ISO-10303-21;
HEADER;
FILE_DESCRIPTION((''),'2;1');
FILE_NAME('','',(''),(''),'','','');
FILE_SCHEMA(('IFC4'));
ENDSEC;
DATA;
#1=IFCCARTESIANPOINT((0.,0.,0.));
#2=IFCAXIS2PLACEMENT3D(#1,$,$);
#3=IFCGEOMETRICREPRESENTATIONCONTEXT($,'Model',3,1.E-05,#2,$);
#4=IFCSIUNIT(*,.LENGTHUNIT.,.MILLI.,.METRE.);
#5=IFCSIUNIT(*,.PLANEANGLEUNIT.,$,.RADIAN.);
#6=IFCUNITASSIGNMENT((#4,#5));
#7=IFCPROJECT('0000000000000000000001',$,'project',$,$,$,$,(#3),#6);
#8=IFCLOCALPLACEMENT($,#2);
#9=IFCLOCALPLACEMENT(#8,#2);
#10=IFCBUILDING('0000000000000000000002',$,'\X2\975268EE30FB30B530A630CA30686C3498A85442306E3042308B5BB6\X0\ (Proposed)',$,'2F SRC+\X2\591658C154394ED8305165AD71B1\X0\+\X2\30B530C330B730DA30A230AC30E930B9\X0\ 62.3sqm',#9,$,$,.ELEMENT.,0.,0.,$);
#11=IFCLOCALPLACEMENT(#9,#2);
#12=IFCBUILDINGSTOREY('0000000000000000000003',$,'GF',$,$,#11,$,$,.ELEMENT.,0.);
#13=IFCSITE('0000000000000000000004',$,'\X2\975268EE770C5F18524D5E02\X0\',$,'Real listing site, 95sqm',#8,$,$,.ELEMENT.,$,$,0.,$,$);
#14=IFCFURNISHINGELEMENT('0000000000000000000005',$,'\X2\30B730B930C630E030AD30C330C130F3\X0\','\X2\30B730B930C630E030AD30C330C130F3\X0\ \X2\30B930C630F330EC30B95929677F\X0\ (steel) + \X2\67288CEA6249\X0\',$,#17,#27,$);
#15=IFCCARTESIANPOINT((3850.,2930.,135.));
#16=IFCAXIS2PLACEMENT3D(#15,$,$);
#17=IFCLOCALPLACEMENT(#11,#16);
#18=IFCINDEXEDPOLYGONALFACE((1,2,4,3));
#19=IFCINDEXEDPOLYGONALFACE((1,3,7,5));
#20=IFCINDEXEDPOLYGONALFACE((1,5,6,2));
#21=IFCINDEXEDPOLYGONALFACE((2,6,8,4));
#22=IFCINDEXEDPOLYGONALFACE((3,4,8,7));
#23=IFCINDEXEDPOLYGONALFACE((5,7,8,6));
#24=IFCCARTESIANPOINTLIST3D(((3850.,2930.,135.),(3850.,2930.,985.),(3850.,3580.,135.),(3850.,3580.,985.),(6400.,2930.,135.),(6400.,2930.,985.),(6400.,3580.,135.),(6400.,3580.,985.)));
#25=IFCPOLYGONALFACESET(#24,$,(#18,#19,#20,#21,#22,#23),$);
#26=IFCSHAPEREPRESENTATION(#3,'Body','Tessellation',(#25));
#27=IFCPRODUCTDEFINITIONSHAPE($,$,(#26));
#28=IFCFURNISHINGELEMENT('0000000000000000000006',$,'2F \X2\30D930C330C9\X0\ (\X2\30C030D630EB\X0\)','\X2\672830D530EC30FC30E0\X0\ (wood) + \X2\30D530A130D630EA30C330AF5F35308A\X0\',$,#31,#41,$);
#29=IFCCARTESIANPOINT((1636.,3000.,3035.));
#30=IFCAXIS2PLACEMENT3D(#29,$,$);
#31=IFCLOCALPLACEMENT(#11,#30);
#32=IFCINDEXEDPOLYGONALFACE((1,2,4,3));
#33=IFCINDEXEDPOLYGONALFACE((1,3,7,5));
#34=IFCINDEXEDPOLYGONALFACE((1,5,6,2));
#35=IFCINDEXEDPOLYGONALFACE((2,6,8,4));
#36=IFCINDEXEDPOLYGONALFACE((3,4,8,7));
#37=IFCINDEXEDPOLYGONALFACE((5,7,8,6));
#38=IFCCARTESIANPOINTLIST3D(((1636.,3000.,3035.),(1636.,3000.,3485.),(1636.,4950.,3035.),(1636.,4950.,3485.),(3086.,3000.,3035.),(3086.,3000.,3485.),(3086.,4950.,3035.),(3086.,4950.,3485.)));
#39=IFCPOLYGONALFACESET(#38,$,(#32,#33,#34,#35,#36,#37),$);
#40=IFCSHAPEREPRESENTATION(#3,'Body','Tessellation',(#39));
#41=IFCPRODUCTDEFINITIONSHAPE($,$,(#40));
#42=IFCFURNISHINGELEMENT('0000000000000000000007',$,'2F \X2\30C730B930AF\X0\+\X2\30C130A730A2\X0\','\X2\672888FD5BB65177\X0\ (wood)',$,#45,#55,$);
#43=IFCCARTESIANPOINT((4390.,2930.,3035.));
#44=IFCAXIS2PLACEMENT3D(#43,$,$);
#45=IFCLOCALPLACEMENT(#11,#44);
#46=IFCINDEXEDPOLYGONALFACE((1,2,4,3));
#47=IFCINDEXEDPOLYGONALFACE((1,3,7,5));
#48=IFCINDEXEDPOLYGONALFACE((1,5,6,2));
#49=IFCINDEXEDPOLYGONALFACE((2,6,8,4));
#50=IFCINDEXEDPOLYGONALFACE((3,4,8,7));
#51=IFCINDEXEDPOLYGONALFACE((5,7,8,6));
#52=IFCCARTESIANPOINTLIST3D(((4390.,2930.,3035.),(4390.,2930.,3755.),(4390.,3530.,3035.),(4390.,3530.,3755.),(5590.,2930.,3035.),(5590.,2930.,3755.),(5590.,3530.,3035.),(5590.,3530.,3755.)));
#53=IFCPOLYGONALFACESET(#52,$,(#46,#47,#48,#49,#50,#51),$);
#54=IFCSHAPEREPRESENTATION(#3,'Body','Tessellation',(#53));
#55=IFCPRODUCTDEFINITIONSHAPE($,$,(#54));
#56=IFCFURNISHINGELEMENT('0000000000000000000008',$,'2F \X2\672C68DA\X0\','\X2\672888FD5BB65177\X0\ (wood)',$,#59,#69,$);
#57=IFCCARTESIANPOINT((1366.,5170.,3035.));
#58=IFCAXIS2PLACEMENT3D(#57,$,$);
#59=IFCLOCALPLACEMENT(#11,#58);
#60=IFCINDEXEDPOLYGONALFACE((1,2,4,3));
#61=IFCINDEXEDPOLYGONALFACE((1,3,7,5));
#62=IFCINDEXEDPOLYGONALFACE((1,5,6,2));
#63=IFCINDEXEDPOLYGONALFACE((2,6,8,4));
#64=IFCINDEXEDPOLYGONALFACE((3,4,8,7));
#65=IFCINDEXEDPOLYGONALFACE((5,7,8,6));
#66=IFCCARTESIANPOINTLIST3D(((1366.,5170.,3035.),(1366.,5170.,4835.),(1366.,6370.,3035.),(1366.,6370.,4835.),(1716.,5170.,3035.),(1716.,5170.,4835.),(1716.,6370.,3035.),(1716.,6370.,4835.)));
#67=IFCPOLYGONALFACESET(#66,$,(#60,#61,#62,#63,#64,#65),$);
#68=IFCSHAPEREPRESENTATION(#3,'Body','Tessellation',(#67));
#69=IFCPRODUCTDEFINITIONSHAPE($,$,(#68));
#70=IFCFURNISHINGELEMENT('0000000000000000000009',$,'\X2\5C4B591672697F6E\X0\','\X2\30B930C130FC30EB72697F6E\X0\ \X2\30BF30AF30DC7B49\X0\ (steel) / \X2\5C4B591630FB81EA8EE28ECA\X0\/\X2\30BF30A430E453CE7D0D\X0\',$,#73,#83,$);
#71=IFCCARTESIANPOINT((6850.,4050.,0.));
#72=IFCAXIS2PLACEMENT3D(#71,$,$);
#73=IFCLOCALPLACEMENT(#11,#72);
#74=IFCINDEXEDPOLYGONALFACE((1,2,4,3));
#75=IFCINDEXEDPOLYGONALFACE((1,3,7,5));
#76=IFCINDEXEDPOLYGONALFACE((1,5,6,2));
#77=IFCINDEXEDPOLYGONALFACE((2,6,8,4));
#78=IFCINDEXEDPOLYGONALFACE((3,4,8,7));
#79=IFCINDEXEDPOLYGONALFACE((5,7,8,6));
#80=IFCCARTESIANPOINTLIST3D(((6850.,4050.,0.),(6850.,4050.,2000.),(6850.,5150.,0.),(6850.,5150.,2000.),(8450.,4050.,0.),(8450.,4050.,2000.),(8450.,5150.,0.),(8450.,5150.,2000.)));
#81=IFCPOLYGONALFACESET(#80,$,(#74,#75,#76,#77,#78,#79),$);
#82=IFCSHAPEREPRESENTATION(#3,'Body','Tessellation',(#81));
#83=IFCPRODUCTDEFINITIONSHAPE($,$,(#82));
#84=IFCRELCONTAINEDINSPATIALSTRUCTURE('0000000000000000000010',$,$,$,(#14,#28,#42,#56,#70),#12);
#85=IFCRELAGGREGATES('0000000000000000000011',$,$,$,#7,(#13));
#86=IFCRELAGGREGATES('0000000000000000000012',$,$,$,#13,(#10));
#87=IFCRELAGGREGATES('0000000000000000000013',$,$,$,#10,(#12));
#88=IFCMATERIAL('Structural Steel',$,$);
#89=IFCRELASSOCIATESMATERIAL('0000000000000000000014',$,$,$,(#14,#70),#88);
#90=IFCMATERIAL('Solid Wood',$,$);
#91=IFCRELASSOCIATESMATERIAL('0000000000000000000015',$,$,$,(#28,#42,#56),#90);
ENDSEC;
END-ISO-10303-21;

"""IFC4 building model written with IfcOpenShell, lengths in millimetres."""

from ifc_helpers import new_model, si_unit, frame, frame_2d, origin, place, context, project, spatial, rectangle, extrude, material, element, save


model = new_model("IFC4")

# Units and contexts
model_context = context("Model", 3, precision=1e-05, world=origin())
ifc_project = project(units=[si_unit("LENGTHUNIT", "METRE", prefix="MILLI"), si_unit("PLANEANGLEUNIT", "RADIAN")], contexts=[model_context])

# Site, building, storey
site_placement = place(None, origin())
site = spatial("IfcSite", under=ifc_project, at=site_placement, Name="青森県弘前市", ObjectType="Real listing site, 95sqm", CompositionType="ELEMENT", RefElevation=0.0)
building_placement = place(site_placement, origin())
building = spatial("IfcBuilding", under=site, at=building_placement, Name="青森・サウナと水風呂のある家 (Proposed)", ObjectType="2F SRC+外壁吹付け断熱+サッシペアガラス 62.3sqm", CompositionType="ELEMENT", ElevationOfRefHeight=0.0, ElevationOfTerrain=0.0)
storey_placement = place(building_placement, origin())
storey = spatial("IfcBuildingStorey", under=building, at=storey_placement, Name="GF", CompositionType="ELEMENT", Elevation=0.0)

# Shared definitions
ifc_material_1 = material(Name="Solid Wood")

# Shared definitions
ifc_material_2 = material(Name="Structural Steel")

# Furnishing elements
furnishing_1_placement = place(storey_placement, frame((3850.0, 2930.0, 135.0)))
element("IfcFurnishingElement", 1, at=furnishing_1_placement, inside=storey, material=ifc_material_2, Name="システムキッチン", Description="システムキッチン ステンレス天板 (steel) + 木質扉", context=model_context, shape_type="SweptSolid", body=[
    extrude(rectangle(XDim=2550.0, YDim=650.0, at=frame_2d((1275.0, 325.0))), frame((3850.0, 2930.0, 135.0)), (0.0, 0.0, 1.0), 850.0),
])
furnishing_2_placement = place(storey_placement, frame((1636.0, 3000.0, 3035.0)))
element("IfcFurnishingElement", 2, at=furnishing_2_placement, inside=storey, material=ifc_material_1, Name="2F ベッド (ダブル)", Description="木フレーム (wood) + ファブリック張り", context=model_context, shape_type="SweptSolid", body=[
    extrude(rectangle(XDim=1450.0, YDim=1950.0, at=frame_2d((725.0, 975.0))), frame((1636.0, 3000.0, 3035.0)), (0.0, 0.0, 1.0), 450.0),
])
furnishing_3_placement = place(storey_placement, frame((4390.0, 2930.0, 3035.0)))
element("IfcFurnishingElement", 3, at=furnishing_3_placement, inside=storey, material=ifc_material_1, Name="2F デスク+チェア", Description="木製家具 (wood)", context=model_context, shape_type="SweptSolid", body=[
    extrude(rectangle(XDim=1200.0, YDim=600.0, at=frame_2d((600.0, 300.0))), frame((4390.0, 2930.0, 3035.0)), (0.0, 0.0, 1.0), 720.0),
])
furnishing_4_placement = place(storey_placement, frame((1366.0, 5170.0, 3035.0)))
element("IfcFurnishingElement", 4, at=furnishing_4_placement, inside=storey, material=ifc_material_1, Name="2F 本棚", Description="木製家具 (wood)", context=model_context, shape_type="SweptSolid", body=[
    extrude(rectangle(XDim=350.0, YDim=1200.0, at=frame_2d((175.0, 600.0))), frame((1366.0, 5170.0, 3035.0)), (0.0, 0.0, 1.0), 1800.0),
])
furnishing_5_placement = place(storey_placement, frame((6850.0, 4050.0, 0.0)))
element("IfcFurnishingElement", 5, at=furnishing_5_placement, inside=storey, material=ifc_material_2, Name="屋外物置", Description="スチール物置 タクボ等 (steel) / 屋外・自転車/タイヤ収納", context=model_context, shape_type="SweptSolid", body=[
    extrude(rectangle(XDim=1600.0, YDim=1100.0, at=frame_2d((800.0, 550.0))), frame((6850.0, 4050.0, 0.0)), (0.0, 0.0, 1.0), 2000.0),
])

save(model, "model.ifc")
